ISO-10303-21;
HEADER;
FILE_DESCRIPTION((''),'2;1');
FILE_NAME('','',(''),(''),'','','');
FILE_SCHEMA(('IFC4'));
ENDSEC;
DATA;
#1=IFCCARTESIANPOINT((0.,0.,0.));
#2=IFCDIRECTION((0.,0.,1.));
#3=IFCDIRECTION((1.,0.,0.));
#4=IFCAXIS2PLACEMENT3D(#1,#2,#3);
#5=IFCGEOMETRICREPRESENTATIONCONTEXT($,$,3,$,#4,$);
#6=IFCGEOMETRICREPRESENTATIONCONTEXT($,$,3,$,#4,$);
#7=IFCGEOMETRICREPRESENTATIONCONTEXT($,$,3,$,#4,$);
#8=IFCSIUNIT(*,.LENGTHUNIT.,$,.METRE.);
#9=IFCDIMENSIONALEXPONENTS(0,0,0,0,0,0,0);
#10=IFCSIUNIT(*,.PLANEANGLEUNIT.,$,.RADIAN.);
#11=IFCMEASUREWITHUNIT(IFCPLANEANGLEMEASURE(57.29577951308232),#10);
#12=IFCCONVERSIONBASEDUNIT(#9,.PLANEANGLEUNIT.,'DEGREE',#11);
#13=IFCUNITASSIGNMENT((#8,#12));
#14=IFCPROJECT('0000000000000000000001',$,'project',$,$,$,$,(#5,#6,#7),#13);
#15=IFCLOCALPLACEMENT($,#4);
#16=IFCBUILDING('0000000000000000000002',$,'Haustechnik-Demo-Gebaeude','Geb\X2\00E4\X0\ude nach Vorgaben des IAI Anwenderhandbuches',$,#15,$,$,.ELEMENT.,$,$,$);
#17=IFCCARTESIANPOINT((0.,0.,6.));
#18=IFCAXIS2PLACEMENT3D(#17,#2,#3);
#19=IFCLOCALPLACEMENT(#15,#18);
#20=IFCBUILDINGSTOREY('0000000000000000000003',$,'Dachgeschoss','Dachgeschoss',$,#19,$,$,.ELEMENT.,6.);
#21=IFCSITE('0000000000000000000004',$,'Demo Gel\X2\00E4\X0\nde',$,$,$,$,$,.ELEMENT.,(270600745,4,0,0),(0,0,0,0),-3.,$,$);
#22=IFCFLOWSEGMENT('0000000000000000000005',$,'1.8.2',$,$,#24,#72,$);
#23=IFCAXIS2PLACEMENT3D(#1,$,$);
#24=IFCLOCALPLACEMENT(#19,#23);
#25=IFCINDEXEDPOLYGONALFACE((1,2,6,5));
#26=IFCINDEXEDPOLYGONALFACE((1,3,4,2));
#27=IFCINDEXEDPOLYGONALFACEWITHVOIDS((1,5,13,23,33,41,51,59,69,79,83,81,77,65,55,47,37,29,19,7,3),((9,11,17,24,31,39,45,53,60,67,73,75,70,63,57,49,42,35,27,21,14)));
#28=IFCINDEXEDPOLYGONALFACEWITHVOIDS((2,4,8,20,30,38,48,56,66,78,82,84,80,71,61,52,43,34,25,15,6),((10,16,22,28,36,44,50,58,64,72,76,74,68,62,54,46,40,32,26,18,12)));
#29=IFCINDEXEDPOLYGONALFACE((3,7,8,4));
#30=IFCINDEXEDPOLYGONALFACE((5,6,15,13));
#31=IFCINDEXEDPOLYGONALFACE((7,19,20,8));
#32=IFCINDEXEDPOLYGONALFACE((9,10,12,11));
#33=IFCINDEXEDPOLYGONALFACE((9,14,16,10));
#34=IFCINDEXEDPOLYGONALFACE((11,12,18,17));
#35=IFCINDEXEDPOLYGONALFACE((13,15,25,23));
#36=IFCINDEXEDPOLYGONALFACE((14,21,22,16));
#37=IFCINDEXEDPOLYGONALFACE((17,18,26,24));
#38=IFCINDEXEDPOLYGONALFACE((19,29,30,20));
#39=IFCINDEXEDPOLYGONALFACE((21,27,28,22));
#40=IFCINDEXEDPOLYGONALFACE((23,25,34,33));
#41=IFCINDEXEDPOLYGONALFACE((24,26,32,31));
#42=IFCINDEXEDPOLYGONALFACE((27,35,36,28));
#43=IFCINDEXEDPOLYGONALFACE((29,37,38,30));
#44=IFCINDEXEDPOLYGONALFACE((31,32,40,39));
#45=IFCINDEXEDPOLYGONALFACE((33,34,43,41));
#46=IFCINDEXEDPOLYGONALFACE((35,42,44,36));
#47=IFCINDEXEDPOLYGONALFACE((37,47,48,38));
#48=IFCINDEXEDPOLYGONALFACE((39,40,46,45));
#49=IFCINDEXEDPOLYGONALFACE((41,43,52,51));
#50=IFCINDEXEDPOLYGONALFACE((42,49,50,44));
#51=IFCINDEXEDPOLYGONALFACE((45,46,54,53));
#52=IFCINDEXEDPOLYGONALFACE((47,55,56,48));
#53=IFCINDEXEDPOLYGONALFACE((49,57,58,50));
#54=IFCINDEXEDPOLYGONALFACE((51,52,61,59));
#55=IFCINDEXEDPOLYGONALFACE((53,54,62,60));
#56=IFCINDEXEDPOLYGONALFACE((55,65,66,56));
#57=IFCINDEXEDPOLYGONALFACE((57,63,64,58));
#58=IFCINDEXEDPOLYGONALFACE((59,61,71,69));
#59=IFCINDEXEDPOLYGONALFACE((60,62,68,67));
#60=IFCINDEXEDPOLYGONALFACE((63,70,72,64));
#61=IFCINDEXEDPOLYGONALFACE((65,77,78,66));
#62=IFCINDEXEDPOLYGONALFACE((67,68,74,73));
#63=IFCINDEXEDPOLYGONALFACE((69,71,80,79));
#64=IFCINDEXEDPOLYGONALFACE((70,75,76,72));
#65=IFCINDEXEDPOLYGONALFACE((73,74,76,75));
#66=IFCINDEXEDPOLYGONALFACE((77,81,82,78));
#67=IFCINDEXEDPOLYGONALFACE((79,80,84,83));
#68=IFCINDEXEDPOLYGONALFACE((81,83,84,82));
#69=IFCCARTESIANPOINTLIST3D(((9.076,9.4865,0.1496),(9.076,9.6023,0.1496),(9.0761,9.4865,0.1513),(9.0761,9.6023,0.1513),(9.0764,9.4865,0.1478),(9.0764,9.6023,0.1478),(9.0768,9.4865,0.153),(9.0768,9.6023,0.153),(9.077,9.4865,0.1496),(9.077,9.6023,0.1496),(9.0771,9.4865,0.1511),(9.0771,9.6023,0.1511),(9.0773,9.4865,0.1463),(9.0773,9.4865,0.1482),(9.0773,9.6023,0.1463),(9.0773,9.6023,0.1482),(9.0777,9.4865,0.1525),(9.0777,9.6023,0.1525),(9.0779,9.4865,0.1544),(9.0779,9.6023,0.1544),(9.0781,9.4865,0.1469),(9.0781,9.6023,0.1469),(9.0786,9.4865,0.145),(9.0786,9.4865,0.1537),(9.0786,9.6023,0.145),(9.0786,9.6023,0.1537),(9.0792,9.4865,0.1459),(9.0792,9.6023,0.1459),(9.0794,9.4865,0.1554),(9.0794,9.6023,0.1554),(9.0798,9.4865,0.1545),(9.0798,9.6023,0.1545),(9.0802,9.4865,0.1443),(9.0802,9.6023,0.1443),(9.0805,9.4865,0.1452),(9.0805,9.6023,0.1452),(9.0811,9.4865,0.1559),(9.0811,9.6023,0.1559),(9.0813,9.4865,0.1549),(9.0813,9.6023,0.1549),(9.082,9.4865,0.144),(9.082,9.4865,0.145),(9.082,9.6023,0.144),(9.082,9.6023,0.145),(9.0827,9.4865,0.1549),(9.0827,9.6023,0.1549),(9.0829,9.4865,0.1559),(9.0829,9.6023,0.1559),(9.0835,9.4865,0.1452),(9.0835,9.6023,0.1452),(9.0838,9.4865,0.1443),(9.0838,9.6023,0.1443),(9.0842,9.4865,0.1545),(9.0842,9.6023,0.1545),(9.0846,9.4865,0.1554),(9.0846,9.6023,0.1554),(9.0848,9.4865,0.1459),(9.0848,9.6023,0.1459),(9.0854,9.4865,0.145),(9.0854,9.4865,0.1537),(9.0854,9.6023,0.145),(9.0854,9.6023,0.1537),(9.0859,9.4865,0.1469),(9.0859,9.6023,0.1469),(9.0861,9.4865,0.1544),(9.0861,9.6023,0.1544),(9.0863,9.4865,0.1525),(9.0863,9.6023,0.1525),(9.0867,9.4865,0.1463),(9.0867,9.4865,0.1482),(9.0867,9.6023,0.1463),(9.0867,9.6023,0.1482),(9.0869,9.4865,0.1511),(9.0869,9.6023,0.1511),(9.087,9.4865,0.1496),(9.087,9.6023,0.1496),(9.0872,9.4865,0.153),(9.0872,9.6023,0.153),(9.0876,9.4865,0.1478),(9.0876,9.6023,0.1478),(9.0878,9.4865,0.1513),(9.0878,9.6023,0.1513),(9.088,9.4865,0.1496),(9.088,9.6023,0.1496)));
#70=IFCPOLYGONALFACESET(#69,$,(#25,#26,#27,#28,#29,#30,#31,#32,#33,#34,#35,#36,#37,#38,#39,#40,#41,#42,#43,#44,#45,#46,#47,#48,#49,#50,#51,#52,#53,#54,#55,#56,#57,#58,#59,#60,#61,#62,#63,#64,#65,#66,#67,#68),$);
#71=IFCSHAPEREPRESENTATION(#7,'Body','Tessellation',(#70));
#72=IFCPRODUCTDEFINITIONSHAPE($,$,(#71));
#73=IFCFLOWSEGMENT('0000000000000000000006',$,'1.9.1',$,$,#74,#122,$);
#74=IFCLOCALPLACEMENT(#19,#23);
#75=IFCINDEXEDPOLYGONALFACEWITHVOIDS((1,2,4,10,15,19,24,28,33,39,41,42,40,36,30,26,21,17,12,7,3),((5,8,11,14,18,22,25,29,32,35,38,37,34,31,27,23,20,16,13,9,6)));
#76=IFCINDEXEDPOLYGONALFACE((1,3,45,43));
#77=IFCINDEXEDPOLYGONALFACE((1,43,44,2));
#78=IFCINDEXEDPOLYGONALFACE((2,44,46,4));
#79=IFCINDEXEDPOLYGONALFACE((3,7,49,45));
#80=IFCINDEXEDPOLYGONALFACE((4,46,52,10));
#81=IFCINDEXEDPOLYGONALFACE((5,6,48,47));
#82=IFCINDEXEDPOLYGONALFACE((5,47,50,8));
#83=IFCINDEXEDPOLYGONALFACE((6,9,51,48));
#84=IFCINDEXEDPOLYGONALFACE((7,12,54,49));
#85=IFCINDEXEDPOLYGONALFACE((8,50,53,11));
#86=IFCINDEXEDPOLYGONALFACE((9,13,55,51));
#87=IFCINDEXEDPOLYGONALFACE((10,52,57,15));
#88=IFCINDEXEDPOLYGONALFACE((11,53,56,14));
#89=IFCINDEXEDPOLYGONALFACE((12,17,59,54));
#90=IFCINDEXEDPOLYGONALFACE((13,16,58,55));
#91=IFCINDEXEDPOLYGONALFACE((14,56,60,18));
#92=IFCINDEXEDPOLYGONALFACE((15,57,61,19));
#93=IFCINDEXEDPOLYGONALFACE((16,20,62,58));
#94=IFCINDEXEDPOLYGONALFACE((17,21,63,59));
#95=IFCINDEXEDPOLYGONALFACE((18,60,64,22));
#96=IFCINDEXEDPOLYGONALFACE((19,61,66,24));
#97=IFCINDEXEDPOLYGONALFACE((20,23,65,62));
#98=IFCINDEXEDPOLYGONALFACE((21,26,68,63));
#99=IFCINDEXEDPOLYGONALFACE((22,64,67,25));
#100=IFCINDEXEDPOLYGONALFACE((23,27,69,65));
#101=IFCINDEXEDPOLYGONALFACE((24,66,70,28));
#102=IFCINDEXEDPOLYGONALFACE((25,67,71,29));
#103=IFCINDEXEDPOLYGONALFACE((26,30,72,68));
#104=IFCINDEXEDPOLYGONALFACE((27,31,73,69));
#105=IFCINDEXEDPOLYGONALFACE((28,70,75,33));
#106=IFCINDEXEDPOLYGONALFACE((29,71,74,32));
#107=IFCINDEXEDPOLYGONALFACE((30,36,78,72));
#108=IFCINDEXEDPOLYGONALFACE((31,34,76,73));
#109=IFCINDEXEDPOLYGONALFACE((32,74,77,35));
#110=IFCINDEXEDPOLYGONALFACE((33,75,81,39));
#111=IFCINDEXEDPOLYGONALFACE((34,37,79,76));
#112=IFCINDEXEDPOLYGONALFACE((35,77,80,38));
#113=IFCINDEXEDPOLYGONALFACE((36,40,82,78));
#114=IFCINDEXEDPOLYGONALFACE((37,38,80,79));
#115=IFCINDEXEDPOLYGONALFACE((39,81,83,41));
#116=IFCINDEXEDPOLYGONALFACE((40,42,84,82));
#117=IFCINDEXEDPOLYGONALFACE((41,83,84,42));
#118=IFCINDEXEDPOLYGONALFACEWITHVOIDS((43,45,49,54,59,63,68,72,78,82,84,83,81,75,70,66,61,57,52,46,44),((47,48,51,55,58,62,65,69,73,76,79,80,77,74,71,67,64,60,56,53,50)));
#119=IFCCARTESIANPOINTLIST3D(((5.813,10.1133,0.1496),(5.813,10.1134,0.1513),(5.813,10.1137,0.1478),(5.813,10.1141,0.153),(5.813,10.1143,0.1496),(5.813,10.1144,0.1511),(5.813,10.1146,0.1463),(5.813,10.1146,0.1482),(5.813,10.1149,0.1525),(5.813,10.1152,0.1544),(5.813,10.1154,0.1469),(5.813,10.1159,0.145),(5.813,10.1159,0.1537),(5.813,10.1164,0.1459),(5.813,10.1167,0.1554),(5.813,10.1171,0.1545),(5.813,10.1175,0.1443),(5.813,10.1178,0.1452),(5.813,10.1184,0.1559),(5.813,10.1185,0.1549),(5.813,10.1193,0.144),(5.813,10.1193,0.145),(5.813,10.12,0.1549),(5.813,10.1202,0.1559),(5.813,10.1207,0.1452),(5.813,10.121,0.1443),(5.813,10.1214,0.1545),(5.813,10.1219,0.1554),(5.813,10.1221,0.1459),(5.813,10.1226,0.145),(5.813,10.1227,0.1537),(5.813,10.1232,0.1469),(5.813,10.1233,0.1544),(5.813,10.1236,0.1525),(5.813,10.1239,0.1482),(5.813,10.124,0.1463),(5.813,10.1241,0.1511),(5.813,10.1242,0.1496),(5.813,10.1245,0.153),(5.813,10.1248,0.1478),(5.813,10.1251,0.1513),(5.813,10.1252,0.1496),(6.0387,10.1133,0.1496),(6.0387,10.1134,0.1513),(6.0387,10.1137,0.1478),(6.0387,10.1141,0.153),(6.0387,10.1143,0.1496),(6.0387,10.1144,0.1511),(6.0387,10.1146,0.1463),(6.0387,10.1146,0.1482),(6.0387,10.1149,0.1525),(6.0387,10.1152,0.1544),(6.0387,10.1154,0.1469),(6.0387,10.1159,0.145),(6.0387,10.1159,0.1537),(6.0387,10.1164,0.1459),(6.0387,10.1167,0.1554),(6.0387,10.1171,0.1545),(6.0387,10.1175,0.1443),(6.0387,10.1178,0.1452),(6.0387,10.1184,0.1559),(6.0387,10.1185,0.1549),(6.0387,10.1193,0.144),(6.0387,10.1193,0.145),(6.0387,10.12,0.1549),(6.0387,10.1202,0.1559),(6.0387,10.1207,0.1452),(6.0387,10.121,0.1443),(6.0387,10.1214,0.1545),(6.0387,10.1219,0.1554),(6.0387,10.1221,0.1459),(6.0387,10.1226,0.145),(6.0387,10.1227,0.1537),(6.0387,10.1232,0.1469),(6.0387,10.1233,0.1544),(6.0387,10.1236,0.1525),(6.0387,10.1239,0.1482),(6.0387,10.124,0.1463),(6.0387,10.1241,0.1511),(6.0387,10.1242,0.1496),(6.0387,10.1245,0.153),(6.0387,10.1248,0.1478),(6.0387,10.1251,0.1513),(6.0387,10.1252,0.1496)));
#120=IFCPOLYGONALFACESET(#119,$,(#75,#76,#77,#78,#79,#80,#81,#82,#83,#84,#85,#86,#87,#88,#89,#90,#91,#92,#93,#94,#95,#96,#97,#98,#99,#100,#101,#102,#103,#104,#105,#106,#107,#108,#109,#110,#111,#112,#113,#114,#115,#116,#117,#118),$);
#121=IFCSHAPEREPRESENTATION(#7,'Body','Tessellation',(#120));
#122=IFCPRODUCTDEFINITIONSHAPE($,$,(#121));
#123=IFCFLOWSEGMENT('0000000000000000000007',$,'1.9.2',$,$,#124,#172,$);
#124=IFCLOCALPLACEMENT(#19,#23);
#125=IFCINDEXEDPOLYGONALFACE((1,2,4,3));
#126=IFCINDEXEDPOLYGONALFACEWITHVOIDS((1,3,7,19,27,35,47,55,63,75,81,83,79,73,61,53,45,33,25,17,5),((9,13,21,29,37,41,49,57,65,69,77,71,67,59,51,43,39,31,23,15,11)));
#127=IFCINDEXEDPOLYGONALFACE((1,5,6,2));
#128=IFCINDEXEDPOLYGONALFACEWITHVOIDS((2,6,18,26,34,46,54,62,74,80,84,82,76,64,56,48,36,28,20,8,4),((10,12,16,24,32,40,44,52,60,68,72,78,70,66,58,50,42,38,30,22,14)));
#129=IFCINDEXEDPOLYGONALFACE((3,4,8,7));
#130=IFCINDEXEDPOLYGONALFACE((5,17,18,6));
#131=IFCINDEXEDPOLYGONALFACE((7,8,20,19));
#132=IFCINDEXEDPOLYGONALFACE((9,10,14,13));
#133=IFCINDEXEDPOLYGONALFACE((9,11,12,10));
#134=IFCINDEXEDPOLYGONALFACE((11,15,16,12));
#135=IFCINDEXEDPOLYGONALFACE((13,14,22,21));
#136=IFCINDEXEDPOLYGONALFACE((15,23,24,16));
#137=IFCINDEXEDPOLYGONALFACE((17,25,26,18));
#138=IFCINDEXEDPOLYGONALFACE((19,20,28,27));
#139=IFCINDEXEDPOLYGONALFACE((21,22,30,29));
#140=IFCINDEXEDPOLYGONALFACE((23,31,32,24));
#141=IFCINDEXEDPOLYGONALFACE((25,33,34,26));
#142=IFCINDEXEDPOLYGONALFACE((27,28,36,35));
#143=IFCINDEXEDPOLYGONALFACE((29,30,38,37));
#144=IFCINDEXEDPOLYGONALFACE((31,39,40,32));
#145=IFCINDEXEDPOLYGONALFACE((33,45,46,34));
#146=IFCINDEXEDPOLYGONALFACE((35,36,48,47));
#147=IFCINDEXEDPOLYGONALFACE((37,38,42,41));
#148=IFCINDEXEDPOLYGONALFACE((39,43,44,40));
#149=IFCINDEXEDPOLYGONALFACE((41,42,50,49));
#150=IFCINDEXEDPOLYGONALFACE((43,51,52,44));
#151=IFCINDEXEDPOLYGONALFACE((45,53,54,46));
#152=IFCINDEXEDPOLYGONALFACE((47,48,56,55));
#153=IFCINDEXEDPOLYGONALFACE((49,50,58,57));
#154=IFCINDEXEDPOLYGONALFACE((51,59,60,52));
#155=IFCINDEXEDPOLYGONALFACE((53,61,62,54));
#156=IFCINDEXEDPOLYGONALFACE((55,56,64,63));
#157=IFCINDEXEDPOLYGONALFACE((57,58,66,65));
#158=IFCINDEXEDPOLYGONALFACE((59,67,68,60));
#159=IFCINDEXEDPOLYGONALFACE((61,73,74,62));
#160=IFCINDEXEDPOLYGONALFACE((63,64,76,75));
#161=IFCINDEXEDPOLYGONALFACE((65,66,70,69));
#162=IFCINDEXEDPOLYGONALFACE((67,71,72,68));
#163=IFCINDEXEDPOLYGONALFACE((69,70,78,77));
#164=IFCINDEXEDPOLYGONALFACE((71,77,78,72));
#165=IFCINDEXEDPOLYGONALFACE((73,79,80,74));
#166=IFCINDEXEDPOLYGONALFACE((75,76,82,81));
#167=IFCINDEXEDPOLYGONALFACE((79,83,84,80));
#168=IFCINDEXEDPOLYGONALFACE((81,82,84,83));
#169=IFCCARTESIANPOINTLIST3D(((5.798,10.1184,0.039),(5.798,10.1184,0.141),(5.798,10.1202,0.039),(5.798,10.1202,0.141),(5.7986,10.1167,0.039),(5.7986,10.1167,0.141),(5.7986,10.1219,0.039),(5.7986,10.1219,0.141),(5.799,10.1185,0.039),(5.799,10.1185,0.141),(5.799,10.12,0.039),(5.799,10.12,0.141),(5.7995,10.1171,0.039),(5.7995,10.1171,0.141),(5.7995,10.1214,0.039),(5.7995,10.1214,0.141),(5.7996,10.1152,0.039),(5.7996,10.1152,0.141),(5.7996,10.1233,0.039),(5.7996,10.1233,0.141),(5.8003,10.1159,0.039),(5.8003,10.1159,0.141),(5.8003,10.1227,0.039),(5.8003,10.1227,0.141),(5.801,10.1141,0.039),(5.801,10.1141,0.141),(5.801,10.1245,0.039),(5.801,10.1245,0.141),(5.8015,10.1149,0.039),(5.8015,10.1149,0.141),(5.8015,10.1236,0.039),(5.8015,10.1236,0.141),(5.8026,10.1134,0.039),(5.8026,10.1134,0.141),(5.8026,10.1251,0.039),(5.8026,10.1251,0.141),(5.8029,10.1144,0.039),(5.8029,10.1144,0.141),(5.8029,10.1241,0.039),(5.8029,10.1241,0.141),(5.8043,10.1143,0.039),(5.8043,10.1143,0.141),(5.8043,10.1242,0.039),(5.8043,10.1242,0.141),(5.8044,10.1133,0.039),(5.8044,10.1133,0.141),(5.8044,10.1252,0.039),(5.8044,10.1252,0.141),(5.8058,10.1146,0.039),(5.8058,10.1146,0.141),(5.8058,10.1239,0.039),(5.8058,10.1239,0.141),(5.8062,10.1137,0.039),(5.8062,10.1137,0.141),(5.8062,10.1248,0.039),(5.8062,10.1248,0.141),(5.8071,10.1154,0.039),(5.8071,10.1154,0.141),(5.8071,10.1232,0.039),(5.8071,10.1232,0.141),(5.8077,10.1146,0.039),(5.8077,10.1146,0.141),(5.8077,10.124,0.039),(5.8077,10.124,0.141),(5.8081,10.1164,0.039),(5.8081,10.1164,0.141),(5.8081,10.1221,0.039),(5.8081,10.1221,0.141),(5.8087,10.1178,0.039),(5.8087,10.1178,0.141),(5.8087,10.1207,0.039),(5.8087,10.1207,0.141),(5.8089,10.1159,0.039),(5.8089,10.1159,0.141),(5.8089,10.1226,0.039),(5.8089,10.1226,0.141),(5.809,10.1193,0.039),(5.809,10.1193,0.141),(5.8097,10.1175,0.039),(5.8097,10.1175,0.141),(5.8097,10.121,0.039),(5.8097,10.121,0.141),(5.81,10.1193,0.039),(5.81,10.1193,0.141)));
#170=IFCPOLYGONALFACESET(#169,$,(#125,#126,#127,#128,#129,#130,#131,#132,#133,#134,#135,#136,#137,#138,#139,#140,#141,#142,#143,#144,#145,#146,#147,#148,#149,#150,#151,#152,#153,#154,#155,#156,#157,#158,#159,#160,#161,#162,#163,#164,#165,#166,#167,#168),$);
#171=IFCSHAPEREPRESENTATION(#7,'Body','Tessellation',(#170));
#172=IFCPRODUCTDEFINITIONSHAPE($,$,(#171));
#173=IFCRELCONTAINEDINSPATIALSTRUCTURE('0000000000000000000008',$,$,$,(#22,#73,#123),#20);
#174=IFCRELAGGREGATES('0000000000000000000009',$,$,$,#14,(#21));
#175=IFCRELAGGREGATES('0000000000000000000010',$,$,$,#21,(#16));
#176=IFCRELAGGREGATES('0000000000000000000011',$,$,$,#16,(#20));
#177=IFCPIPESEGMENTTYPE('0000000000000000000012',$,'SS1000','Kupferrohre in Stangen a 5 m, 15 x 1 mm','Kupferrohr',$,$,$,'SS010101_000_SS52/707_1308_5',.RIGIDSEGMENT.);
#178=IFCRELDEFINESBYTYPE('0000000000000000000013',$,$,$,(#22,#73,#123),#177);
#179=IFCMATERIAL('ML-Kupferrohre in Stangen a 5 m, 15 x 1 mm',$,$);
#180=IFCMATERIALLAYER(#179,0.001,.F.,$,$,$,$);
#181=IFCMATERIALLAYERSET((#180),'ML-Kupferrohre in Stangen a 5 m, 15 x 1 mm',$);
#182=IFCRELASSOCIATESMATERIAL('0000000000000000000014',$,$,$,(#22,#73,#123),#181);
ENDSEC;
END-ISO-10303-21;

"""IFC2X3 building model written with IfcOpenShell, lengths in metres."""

from ifc_helpers import new_model, entity, si_unit, converted_unit, frame, origin_with_axes, origin_2d_with_axis, place, context, project, spatial, hollow_circle, extrude, material, layer, layer_set, layer_usage, type_object, element, save


model = new_model("IFC2X3")

# Units and contexts
context_of_model_1 = context(None, 3, world=origin_with_axes())
context_of_model_2 = context(None, 3, world=origin_with_axes())
context_of_model_3 = context(None, 3, world=origin_with_axes())
ifc_project = project(units=[si_unit("LENGTHUNIT", "METRE"), converted_unit("PLANEANGLEUNIT", "DEGREE", entity("IfcPlaneAngleMeasure", 57.29577951308232), si_unit("PLANEANGLEUNIT", "RADIAN"), dimensions=[0, 0, 0, 0, 0, 0, 0])], contexts=[context_of_model_1, context_of_model_2, context_of_model_3])

# Site, building, storey
site = spatial("IfcSite", under=ifc_project, Name="Demo Gelände", CompositionType="ELEMENT", RefLatitude=(270600745, 4, 0, 0), RefLongitude=(0, 0, 0, 0), RefElevation=-3.0)
building_placement = place(None, origin_with_axes())
building = spatial("IfcBuilding", under=site, at=building_placement, Name="Haustechnik-Demo-Gebaeude", Description="Gebäude nach Vorgaben des IAI Anwenderhandbuches", CompositionType="ELEMENT")
storey_placement = place(building_placement, frame((0.0, 0.0, 6.0), z_axis=(0.0, 0.0, 1.0), x_axis=(1.0, 0.0, 0.0)))
storey = spatial("IfcBuildingStorey", under=building, at=storey_placement, Name="Dachgeschoss", Description="Dachgeschoss", CompositionType="ELEMENT", Elevation=6.0)

# Flow segments
ifc_material = material(Name="ML-Kupferrohre in Stangen a 5 m, 15 x 1 mm")
ifc_layer = layer(ifc_material, 0.001, ventilated=False)
ifc_layer_set = layer_set([ifc_layer], Name="ML-Kupferrohre in Stangen a 5 m, 15 x 1 mm")
ifc_layer_usage = layer_usage(ifc_layer_set, "AXIS2", "POSITIVE", 0.0)
pipe_segment_type_1 = type_object("IfcPipeSegmentType", Name="SS1000", Description="Kupferrohre in Stangen a 5 m, 15 x 1 mm", ApplicableOccurrence="Kupferrohr", ElementType="SS010101_000_SS52/707_1308_5", PredefinedType="RIGIDSEGMENT")
flow_segment_1_placement = place(storey_placement, frame((9.082, 9.6023, 0.15), z_axis=(-0.000003, -1.0, 0.0), x_axis=(0.0, 0.0, -1.0)))
element("IfcFlowSegment", 1, at=flow_segment_1_placement, inside=storey, type_object=pipe_segment_type_1, material=ifc_layer_usage, Name="1.8.2", context=context_of_model_3, shape_type="SweptSolid", body=[
    extrude(hollow_circle(Radius=0.006, WallThickness=0.001, at=origin_2d_with_axis()), origin_with_axes(), (0.0, 0.0, 1.0), 0.1158),
])
flow_segment_2_placement = place(storey_placement, frame((6.0387, 10.1193, 0.15), z_axis=(-1.0, 0.0, 0.0), x_axis=(0.0, 0.0, -1.0)))
element("IfcFlowSegment", 2, at=flow_segment_2_placement, inside=storey, type_object=pipe_segment_type_1, material=ifc_layer_usage, Name="1.9.1", context=context_of_model_3, shape_type="SweptSolid", body=[
    extrude(hollow_circle(Radius=0.006, WallThickness=0.001, at=origin_2d_with_axis()), origin_with_axes(), (0.0, 0.0, 1.0), 0.2257),
])
flow_segment_3_placement = place(storey_placement, frame((5.804, 10.1193, 0.141), z_axis=(0.0, 0.0, -1.0), x_axis=(1.0, 0.0, 0.0)))
element("IfcFlowSegment", 3, at=flow_segment_3_placement, inside=storey, type_object=pipe_segment_type_1, material=ifc_layer_usage, Name="1.9.2", context=context_of_model_3, shape_type="SweptSolid", body=[
    extrude(hollow_circle(Radius=0.006, WallThickness=0.001, at=origin_2d_with_axis()), origin_with_axes(), (0.0, 0.0, 1.0), 0.102),
])

save(model, "model.ifc")
